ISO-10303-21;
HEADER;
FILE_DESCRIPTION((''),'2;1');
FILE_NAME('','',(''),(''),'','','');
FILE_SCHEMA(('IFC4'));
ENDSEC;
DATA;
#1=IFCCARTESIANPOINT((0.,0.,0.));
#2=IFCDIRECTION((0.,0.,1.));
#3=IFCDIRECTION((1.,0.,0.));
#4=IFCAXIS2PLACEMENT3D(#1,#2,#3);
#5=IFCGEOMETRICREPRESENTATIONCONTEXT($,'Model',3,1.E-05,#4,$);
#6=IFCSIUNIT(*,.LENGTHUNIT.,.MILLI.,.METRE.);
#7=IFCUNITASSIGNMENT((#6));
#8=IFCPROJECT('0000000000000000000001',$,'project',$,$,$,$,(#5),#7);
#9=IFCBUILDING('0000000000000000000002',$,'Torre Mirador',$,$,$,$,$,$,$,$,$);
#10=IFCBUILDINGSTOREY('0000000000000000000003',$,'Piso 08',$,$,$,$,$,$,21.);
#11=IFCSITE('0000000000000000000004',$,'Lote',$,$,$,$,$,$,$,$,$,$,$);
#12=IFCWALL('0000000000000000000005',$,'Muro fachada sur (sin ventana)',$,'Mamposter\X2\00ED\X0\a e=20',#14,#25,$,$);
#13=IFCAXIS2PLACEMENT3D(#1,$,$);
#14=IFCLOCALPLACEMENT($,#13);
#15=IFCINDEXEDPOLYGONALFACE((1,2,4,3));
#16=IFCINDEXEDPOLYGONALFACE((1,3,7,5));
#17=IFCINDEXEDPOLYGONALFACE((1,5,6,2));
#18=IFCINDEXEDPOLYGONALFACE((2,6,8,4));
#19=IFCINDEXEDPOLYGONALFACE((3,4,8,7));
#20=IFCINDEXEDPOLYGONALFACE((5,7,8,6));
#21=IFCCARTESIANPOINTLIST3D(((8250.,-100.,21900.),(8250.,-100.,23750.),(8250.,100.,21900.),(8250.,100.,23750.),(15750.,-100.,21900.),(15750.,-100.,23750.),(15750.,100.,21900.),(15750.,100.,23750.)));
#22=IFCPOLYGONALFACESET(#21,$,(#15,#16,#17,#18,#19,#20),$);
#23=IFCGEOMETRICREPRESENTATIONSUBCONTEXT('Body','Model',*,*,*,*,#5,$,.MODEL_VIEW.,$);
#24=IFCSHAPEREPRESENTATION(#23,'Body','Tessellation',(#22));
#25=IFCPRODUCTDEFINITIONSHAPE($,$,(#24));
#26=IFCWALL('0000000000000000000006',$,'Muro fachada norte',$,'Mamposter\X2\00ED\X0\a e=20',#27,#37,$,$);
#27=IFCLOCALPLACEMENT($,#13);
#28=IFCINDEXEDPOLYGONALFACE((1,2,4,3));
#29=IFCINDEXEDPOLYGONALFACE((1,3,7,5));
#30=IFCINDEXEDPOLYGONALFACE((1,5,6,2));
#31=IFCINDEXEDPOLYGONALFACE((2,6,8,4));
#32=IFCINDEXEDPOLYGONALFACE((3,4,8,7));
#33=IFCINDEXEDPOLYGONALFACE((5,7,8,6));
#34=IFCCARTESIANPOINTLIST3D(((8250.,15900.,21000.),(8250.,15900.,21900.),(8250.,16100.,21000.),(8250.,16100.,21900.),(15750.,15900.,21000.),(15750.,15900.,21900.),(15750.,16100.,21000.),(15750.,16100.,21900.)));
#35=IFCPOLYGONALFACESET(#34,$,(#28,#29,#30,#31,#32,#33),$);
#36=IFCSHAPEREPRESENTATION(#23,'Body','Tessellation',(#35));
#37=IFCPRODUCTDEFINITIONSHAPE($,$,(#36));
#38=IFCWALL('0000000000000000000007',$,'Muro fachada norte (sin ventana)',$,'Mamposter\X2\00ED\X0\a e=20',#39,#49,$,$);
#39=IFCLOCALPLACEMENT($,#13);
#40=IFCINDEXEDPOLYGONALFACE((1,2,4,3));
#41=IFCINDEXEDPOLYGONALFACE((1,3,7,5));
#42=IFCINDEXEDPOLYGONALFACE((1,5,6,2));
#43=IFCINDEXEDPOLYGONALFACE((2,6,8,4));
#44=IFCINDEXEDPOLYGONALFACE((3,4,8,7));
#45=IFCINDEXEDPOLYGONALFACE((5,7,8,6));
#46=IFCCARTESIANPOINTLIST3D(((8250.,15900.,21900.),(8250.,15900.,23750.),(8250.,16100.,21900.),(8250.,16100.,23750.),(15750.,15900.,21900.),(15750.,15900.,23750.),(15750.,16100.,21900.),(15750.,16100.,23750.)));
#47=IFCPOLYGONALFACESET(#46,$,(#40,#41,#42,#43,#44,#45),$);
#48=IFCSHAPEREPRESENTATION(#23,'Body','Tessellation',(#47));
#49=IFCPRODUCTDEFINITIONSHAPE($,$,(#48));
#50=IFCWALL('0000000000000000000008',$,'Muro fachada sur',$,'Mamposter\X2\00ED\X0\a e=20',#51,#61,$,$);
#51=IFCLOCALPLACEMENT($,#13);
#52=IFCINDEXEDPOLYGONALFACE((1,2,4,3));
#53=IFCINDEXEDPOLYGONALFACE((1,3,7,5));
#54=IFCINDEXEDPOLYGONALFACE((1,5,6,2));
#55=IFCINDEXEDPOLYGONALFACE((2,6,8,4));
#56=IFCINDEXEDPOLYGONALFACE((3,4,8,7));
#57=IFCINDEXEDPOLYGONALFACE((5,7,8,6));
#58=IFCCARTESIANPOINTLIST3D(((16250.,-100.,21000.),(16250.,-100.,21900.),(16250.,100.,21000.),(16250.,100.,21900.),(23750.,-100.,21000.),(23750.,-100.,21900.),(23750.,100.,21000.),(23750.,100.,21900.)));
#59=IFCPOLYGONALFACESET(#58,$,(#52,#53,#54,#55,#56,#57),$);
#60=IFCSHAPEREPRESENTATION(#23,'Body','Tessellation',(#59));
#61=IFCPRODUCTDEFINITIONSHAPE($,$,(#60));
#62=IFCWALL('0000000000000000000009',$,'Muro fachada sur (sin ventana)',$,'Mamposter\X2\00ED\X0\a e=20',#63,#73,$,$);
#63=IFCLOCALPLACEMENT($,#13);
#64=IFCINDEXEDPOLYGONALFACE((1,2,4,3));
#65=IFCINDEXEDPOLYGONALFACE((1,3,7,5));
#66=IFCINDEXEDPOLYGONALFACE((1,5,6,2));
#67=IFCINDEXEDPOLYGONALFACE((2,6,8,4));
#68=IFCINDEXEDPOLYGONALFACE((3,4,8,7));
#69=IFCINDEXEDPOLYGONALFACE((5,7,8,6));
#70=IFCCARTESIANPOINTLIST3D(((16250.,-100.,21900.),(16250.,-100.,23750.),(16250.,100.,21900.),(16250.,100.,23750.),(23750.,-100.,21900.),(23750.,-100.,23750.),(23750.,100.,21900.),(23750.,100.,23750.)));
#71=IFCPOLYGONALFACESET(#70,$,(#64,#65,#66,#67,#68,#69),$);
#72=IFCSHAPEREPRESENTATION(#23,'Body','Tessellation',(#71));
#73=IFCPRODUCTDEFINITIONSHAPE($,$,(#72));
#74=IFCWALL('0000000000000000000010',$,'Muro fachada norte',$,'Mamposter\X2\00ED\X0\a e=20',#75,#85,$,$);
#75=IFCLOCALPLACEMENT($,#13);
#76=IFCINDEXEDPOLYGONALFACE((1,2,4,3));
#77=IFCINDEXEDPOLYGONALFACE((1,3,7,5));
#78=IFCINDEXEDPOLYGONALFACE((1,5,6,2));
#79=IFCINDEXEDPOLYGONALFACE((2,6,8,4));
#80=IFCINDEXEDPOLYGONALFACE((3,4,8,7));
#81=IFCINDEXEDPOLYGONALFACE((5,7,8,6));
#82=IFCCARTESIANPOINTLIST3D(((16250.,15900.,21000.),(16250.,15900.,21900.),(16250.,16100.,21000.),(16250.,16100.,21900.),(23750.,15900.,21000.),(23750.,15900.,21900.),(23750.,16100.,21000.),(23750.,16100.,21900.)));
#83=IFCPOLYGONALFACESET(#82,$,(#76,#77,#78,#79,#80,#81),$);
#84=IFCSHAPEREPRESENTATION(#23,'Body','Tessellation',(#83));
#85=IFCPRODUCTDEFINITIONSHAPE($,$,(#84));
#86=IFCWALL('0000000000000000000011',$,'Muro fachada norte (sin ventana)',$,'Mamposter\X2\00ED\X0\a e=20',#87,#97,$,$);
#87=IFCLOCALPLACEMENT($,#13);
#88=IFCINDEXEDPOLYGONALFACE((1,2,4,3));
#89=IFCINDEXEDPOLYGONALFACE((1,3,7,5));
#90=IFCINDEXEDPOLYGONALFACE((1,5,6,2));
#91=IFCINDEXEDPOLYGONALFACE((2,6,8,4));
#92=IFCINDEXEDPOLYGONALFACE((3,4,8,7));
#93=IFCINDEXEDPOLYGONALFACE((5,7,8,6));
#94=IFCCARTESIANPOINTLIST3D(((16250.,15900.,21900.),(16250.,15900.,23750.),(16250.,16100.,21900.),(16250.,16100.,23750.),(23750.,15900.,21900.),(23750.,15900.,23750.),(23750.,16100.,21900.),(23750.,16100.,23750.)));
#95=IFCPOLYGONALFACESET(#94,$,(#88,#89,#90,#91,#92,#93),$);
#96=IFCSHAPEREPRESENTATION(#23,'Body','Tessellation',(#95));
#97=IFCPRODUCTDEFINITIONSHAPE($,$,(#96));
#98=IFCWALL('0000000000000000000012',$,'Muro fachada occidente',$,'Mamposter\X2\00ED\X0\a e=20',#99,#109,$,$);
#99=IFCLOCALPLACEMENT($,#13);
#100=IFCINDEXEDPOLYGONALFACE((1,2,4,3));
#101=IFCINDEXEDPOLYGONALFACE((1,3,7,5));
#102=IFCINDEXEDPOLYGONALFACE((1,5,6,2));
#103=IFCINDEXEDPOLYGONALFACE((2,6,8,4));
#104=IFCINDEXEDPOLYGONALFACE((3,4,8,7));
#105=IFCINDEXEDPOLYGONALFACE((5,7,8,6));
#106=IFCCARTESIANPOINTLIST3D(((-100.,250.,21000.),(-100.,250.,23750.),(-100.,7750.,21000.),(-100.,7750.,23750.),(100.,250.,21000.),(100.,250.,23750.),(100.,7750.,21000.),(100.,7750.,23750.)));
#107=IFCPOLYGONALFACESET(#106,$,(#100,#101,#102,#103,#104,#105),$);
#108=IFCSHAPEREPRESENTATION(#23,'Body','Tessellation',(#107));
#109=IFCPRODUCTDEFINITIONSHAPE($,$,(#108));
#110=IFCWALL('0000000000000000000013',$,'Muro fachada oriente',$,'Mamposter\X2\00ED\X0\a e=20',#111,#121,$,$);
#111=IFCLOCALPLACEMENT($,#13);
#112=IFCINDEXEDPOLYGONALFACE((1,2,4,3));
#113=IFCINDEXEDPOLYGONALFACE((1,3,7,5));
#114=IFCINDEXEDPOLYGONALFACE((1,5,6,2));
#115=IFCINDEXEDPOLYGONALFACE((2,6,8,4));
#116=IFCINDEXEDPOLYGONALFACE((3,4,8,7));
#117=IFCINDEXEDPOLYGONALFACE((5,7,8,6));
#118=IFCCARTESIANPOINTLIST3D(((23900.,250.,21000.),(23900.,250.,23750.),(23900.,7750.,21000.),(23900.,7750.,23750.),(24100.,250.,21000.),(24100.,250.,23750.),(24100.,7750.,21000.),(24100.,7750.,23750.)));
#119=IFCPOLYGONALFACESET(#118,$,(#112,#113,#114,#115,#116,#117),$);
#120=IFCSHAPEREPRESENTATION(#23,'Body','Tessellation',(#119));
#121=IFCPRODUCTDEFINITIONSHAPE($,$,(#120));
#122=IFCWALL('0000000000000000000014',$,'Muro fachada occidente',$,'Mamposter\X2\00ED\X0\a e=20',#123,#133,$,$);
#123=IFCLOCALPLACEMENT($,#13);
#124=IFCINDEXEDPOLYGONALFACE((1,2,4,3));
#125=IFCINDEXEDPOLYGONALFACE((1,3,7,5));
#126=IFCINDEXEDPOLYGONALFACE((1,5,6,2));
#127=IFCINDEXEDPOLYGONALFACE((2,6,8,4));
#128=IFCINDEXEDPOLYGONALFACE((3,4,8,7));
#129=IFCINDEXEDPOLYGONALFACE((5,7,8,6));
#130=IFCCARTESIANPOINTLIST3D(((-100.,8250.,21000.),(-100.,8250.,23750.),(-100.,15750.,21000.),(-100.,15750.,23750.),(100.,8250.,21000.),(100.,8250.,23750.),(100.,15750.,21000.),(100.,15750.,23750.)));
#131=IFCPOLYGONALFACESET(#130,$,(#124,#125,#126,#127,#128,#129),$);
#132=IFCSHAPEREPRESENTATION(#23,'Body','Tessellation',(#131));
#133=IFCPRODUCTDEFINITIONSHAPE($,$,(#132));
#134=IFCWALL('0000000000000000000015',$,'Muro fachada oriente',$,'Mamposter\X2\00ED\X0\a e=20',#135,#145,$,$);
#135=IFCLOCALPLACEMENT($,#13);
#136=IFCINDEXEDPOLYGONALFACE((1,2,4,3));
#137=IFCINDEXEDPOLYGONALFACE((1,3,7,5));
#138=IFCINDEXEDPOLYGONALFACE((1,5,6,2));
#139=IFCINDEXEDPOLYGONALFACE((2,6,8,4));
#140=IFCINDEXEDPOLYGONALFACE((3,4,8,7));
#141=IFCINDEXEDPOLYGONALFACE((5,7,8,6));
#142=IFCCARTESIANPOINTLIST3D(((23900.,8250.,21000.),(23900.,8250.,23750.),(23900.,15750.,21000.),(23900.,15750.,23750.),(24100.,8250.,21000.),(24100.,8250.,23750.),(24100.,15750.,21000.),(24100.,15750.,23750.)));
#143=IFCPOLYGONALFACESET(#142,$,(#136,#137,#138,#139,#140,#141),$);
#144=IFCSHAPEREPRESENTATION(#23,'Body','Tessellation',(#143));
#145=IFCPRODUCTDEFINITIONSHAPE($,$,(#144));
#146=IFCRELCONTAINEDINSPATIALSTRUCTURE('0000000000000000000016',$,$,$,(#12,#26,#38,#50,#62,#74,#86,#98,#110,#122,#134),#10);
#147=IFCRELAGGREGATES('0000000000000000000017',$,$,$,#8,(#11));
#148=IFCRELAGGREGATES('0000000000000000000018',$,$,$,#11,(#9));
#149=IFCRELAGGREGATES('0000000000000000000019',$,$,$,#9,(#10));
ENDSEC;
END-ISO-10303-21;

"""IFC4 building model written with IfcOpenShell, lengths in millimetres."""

from ifc_helpers import new_model, si_unit, frame, origin_with_axes, place, context, subcontext, project, spatial, indexed_curve, outline, extrude, element, save


model = new_model("IFC4")

# Units and contexts
model_context = context("Model", 3, precision=1e-05, world=origin_with_axes())
body_context = subcontext(model_context, "Body", "Model", "MODEL_VIEW")
ifc_project = project(units=[si_unit("LENGTHUNIT", "METRE", prefix="MILLI")], contexts=[model_context])

# Site, building, storey
site = spatial("IfcSite", under=ifc_project, Name="Lote")
building = spatial("IfcBuilding", under=site, Name="Torre Mirador")
storey = spatial("IfcBuildingStorey", under=building, Name="Piso 08", Elevation=21.0)

# Walls
wall_1_placement = place(None, frame((8250.0, -100.0, 21900.0), z_axis=(0.0, 0.0, 1.0), x_axis=(1.0, 0.0, 0.0)))
element("IfcWall", 1, at=wall_1_placement, inside=storey, Name="Muro fachada sur (sin ventana)", ObjectType="Mampostería e=20", context=body_context, shape_type="SweptSolid", body=[
    extrude(outline(indexed_curve([(0.0, 0.0), (0.0, 200.0), (7500.0, 200.0), (7500.0, 0.0), (0.0, 0.0)], self_intersect=False)), origin_with_axes(), (0.0, 0.0, 1.0), 1850.0),
])
wall_2_placement = place(None, frame((8250.0, 15900.0, 21000.0), z_axis=(0.0, 0.0, 1.0), x_axis=(1.0, 0.0, 0.0)))
element("IfcWall", 2, at=wall_2_placement, inside=storey, Name="Muro fachada norte", ObjectType="Mampostería e=20", context=body_context, shape_type="SweptSolid", body=[
    extrude(outline(indexed_curve([(0.0, 0.0), (0.0, 200.0), (7500.0, 200.0), (7500.0, 0.0), (0.0, 0.0)], self_intersect=False)), origin_with_axes(), (0.0, 0.0, 1.0), 900.0),
])
wall_3_placement = place(None, frame((8250.0, 15900.0, 21900.0), z_axis=(0.0, 0.0, 1.0), x_axis=(1.0, 0.0, 0.0)))
element("IfcWall", 3, at=wall_3_placement, inside=storey, Name="Muro fachada norte (sin ventana)", ObjectType="Mampostería e=20", context=body_context, shape_type="SweptSolid", body=[
    extrude(outline(indexed_curve([(0.0, 0.0), (0.0, 200.0), (7500.0, 200.0), (7500.0, 0.0), (0.0, 0.0)], self_intersect=False)), origin_with_axes(), (0.0, 0.0, 1.0), 1850.0),
])
wall_4_placement = place(None, frame((16250.0, -100.0, 21000.0), z_axis=(0.0, 0.0, 1.0), x_axis=(1.0, 0.0, 0.0)))
element("IfcWall", 4, at=wall_4_placement, inside=storey, Name="Muro fachada sur", ObjectType="Mampostería e=20", context=body_context, shape_type="SweptSolid", body=[
    extrude(outline(indexed_curve([(0.0, 0.0), (0.0, 200.0), (7500.0, 200.0), (7500.0, 0.0), (0.0, 0.0)], self_intersect=False)), origin_with_axes(), (0.0, 0.0, 1.0), 900.0),
])
wall_5_placement = place(None, frame((16250.0, -100.0, 21900.0), z_axis=(0.0, 0.0, 1.0), x_axis=(1.0, 0.0, 0.0)))
element("IfcWall", 5, at=wall_5_placement, inside=storey, Name="Muro fachada sur (sin ventana)", ObjectType="Mampostería e=20", context=body_context, shape_type="SweptSolid", body=[
    extrude(outline(indexed_curve([(0.0, 0.0), (0.0, 200.0), (7500.0, 200.0), (7500.0, 0.0), (0.0, 0.0)], self_intersect=False)), origin_with_axes(), (0.0, 0.0, 1.0), 1850.0),
])
wall_6_placement = place(None, frame((16250.0, 15900.0, 21000.0), z_axis=(0.0, 0.0, 1.0), x_axis=(1.0, 0.0, 0.0)))
element("IfcWall", 6, at=wall_6_placement, inside=storey, Name="Muro fachada norte", ObjectType="Mampostería e=20", context=body_context, shape_type="SweptSolid", body=[
    extrude(outline(indexed_curve([(0.0, 0.0), (0.0, 200.0), (7500.0, 200.0), (7500.0, 0.0), (0.0, 0.0)], self_intersect=False)), origin_with_axes(), (0.0, 0.0, 1.0), 900.0),
])
wall_7_placement = place(None, frame((16250.0, 15900.0, 21900.0), z_axis=(0.0, 0.0, 1.0), x_axis=(1.0, 0.0, 0.0)))
element("IfcWall", 7, at=wall_7_placement, inside=storey, Name="Muro fachada norte (sin ventana)", ObjectType="Mampostería e=20", context=body_context, shape_type="SweptSolid", body=[
    extrude(outline(indexed_curve([(0.0, 0.0), (0.0, 200.0), (7500.0, 200.0), (7500.0, 0.0), (0.0, 0.0)], self_intersect=False)), origin_with_axes(), (0.0, 0.0, 1.0), 1850.0),
])
for number, where, z_axis, x_axis, name in (
    (8, (-100.0, 250.0, 21000.0), (0.0, 0.0, 1.0), (1.0, 0.0, 0.0), "Muro fachada occidente"),
    (9, (23900.0, 250.0, 21000.0), (0.0, 0.0, 1.0), (1.0, 0.0, 0.0), "Muro fachada oriente"),
    (10, (-100.0, 8250.0, 21000.0), (0.0, 0.0, 1.0), (1.0, 0.0, 0.0), "Muro fachada occidente"),
    (11, (23900.0, 8250.0, 21000.0), (0.0, 0.0, 1.0), (1.0, 0.0, 0.0), "Muro fachada oriente"),
):
    element("IfcWall", number, at=place(None, frame(where, z_axis=z_axis, x_axis=x_axis)), inside=storey, Name=name, ObjectType="Mampostería e=20", context=body_context, shape_type="SweptSolid", body=[
        extrude(outline(indexed_curve([(0.0, 0.0), (0.0, 7500.0), (200.0, 7500.0), (200.0, 0.0), (0.0, 0.0)], self_intersect=False)), origin_with_axes(), (0.0, 0.0, 1.0), 2750.0),
    ])

save(model, "model.ifc")
